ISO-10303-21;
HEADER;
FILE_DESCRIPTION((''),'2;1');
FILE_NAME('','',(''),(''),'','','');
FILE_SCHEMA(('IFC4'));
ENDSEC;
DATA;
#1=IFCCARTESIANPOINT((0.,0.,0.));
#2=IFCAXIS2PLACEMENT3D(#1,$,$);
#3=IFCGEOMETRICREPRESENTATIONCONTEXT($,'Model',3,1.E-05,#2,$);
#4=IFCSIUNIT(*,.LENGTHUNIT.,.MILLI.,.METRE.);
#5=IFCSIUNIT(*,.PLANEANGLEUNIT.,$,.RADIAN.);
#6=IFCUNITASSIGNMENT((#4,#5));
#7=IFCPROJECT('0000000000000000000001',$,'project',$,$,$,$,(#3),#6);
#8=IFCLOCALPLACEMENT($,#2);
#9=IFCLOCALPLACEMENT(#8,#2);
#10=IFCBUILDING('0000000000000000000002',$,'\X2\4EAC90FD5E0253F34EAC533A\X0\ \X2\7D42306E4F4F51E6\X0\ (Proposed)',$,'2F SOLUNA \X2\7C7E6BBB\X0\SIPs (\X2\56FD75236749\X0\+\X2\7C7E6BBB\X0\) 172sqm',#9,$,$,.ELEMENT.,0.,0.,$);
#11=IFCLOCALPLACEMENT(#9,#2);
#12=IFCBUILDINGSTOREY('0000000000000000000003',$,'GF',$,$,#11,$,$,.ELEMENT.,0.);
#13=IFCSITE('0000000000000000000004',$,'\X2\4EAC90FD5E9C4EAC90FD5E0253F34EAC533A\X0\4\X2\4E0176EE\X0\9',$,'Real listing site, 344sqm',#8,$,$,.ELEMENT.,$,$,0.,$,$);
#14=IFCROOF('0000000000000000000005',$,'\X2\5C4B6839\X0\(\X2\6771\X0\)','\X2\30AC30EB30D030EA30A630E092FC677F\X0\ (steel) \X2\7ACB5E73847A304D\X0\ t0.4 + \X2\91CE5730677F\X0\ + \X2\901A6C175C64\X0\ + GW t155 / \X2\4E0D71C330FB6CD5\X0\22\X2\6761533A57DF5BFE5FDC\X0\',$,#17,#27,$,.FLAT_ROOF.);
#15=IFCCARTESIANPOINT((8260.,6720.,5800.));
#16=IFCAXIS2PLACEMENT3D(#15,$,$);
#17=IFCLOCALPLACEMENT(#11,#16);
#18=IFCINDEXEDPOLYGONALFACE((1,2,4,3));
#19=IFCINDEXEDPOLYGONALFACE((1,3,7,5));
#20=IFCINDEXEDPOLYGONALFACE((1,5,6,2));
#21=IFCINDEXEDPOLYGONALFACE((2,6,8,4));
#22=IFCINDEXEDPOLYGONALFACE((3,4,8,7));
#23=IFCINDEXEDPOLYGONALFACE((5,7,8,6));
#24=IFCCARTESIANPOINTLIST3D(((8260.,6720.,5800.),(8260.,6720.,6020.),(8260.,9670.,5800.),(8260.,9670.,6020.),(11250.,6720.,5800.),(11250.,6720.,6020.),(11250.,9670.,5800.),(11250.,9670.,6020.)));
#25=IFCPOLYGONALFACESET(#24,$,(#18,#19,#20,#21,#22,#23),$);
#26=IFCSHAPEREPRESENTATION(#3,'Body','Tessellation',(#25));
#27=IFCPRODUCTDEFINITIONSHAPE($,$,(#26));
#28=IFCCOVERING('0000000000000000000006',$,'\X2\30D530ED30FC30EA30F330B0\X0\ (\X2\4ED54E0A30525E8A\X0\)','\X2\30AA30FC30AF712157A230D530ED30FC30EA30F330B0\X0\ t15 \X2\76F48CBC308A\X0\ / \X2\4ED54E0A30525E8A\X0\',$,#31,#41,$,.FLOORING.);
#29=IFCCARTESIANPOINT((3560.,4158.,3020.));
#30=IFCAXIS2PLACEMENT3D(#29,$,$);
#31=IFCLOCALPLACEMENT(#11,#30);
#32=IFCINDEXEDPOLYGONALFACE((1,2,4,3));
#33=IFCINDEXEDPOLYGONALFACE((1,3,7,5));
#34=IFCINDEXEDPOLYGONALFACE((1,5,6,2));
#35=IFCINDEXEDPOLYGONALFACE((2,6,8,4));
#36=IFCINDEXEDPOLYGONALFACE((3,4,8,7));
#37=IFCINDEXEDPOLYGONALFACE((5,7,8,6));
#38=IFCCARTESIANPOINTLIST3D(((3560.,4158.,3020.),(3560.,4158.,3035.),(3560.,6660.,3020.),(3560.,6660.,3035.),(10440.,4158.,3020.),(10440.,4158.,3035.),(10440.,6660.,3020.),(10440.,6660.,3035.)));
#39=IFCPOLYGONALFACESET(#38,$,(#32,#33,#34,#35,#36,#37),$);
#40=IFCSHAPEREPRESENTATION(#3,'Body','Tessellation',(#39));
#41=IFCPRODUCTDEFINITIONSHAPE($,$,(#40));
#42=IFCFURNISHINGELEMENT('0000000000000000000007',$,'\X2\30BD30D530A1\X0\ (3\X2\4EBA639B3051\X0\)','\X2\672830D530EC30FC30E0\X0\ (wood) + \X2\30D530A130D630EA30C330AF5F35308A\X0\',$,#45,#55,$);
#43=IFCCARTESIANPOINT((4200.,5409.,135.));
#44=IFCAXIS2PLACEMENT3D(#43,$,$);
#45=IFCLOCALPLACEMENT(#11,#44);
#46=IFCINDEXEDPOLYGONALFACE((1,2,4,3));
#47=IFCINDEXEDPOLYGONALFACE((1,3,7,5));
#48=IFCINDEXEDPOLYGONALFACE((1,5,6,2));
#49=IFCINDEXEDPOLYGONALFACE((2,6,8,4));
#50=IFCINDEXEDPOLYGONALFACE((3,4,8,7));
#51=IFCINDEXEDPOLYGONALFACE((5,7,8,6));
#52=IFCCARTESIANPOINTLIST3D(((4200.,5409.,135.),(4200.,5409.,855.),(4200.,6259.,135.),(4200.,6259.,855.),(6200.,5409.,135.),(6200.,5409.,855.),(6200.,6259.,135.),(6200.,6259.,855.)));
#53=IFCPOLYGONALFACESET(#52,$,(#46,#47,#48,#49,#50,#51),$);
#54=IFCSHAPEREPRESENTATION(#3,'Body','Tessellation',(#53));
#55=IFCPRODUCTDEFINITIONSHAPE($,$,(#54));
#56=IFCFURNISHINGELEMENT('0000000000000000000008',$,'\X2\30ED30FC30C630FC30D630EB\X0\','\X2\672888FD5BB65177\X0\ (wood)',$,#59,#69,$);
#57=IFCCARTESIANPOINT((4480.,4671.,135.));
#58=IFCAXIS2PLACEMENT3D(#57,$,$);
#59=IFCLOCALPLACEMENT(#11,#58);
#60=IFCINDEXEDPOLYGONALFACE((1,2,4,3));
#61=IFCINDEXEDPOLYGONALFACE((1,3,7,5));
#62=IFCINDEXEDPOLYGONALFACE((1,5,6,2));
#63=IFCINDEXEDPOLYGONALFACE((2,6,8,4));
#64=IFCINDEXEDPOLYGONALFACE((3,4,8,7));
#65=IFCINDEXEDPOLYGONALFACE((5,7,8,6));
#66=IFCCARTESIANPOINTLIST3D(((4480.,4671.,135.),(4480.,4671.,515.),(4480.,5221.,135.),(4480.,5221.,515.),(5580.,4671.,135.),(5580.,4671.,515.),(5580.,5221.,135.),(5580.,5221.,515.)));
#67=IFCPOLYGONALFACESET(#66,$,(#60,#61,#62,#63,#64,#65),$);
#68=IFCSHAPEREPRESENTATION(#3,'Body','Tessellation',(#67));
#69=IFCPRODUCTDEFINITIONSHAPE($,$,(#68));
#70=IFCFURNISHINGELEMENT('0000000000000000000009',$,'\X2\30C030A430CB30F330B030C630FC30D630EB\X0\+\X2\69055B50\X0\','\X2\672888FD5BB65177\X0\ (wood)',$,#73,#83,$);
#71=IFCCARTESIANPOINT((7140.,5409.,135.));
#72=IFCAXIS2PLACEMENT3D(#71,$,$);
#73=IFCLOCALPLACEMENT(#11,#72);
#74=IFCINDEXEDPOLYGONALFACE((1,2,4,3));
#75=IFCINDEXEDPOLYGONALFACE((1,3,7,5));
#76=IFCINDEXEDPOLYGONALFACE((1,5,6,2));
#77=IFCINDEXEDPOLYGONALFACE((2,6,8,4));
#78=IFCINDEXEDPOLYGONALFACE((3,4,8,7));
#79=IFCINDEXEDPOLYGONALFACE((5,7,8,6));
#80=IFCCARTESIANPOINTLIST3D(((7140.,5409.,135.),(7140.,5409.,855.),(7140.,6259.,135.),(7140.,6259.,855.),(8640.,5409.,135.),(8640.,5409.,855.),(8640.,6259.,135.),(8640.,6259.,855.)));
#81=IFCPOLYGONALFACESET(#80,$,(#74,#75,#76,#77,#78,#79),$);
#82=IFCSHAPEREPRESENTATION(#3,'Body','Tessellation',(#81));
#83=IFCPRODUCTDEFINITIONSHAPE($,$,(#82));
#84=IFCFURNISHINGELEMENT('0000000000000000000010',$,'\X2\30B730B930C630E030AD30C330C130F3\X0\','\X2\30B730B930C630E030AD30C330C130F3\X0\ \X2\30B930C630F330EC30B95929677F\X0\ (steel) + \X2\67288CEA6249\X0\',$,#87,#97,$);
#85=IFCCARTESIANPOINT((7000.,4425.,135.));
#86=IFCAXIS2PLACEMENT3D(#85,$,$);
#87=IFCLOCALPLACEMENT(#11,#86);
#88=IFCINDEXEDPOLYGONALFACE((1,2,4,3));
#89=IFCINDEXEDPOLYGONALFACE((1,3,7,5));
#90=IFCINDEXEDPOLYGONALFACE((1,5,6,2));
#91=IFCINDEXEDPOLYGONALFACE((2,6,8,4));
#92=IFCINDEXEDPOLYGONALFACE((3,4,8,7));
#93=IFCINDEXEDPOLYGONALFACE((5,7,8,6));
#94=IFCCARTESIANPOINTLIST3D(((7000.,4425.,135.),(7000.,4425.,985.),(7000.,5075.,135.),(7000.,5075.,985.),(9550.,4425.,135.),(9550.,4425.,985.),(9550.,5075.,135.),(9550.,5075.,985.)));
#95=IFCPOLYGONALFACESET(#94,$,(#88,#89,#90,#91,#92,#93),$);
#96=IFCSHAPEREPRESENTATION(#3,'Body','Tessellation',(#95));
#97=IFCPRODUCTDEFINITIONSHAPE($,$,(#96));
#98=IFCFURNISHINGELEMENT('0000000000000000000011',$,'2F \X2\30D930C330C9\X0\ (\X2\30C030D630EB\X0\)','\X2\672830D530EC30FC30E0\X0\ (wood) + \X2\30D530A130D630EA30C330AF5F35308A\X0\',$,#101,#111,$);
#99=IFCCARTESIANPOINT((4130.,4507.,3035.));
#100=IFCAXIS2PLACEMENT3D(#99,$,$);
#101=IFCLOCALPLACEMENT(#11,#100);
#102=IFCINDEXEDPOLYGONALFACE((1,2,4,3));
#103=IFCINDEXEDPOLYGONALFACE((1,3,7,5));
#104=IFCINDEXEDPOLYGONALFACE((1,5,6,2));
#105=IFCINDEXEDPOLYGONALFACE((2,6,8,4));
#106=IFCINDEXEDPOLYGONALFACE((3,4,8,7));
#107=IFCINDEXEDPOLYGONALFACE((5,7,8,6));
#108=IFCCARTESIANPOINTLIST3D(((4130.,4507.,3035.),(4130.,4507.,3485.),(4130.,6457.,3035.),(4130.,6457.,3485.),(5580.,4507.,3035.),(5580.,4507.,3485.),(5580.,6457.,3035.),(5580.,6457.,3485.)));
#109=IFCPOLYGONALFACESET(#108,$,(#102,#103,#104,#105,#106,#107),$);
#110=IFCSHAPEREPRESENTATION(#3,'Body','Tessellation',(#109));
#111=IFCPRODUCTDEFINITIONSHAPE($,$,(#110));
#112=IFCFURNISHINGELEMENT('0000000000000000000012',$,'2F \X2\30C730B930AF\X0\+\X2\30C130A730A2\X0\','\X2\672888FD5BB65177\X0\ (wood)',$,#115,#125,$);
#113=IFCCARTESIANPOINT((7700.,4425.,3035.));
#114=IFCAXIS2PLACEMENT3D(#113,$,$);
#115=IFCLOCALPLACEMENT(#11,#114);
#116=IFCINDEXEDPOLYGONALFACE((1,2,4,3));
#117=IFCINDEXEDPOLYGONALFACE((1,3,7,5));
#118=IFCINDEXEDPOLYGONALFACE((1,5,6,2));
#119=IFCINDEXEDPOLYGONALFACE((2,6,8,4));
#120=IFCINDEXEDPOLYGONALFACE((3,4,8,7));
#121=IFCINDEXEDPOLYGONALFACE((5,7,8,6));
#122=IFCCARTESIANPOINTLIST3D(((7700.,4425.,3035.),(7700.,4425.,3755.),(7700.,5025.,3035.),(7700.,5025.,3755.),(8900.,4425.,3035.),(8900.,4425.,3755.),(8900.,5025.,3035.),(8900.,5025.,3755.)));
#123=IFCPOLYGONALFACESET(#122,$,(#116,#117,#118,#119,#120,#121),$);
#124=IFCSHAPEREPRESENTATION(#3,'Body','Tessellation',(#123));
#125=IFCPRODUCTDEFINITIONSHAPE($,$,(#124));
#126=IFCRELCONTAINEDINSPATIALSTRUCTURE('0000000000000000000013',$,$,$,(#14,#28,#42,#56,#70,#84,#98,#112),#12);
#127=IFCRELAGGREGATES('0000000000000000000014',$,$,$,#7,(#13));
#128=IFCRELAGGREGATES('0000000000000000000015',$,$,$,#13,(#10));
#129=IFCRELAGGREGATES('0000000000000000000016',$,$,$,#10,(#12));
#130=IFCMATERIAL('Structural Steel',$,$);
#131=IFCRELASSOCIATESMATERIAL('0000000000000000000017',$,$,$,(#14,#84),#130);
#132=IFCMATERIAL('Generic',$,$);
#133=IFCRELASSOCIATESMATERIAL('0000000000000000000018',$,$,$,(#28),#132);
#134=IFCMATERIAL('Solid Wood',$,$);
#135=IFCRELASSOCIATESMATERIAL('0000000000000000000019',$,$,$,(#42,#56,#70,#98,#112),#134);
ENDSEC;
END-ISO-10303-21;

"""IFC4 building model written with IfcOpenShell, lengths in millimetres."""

from ifc_helpers import new_model, si_unit, frame, frame_2d, origin, place, context, project, spatial, rectangle, extrude, material, element, save


model = new_model("IFC4")

# Units and contexts
model_context = context("Model", 3, precision=1e-05, world=origin())
ifc_project = project(units=[si_unit("LENGTHUNIT", "METRE", prefix="MILLI"), si_unit("PLANEANGLEUNIT", "RADIAN")], contexts=[model_context])

# Site, building, storey
site_placement = place(None, origin())
site = spatial("IfcSite", under=ifc_project, at=site_placement, Name="京都府京都市右京区4丁目9", ObjectType="Real listing site, 344sqm", CompositionType="ELEMENT", RefElevation=0.0)
building_placement = place(site_placement, origin())
building = spatial("IfcBuilding", under=site, at=building_placement, Name="京都市右京区 終の住処 (Proposed)", ObjectType="2F SOLUNA 籾殻SIPs (国産杉+籾殻) 172sqm", CompositionType="ELEMENT", ElevationOfRefHeight=0.0, ElevationOfTerrain=0.0)
storey_placement = place(building_placement, origin())
storey = spatial("IfcBuildingStorey", under=building, at=storey_placement, Name="GF", CompositionType="ELEMENT", Elevation=0.0)

# Shared definitions
ifc_material_1 = material(Name="Solid Wood")

# Shared definitions
ifc_material_2 = material(Name="Generic")

# Roof
ifc_material_3 = material(Name="Structural Steel")
roof_placement = place(storey_placement, frame((8260.0, 6720.0, 5800.0)))
element("IfcRoof", 1, at=roof_placement, inside=storey, material=ifc_material_3, Name="屋根(東)", Description="ガルバリウム鋼板 (steel) 立平葺き t0.4 + 野地板 + 通気層 + GW t155 / 不燃・法22条区域対応", PredefinedType="FLAT_ROOF", context=model_context, shape_type="SweptSolid", body=[
    extrude(rectangle(XDim=2990.0, YDim=2950.0, at=frame_2d((1495.0, 1475.0))), frame((8260.0, 6720.0, 5800.0)), (0.0, 0.0, 1.0), 220.0),
])

# Covering
covering_placement = place(storey_placement, frame((3560.0, 4158.0, 3020.0)))
element("IfcCovering", 2, at=covering_placement, inside=storey, material=ifc_material_2, Name="フローリング (仕上げ床)", Description="オーク無垢フローリング t15 直貼り / 仕上げ床", PredefinedType="FLOORING", context=model_context, shape_type="SweptSolid", body=[
    extrude(rectangle(XDim=6880.0, YDim=2502.0, at=frame_2d((3440.0, 1251.0))), frame((3560.0, 4158.0, 3020.0)), (0.0, 0.0, 1.0), 15.0),
])

# Furnishing elements
furnishing_1_placement = place(storey_placement, frame((4200.0, 5409.0, 135.0)))
element("IfcFurnishingElement", 3, at=furnishing_1_placement, inside=storey, material=ifc_material_1, Name="ソファ (3人掛け)", Description="木フレーム (wood) + ファブリック張り", context=model_context, shape_type="SweptSolid", body=[
    extrude(rectangle(XDim=2000.0, YDim=850.0, at=frame_2d((1000.0, 425.0))), frame((4200.0, 5409.0, 135.0)), (0.0, 0.0, 1.0), 720.0),
])
furnishing_2_placement = place(storey_placement, frame((4480.0, 4671.0, 135.0)))
element("IfcFurnishingElement", 4, at=furnishing_2_placement, inside=storey, material=ifc_material_1, Name="ローテーブル", Description="木製家具 (wood)", context=model_context, shape_type="SweptSolid", body=[
    extrude(rectangle(XDim=1100.0, YDim=550.0, at=frame_2d((550.0, 275.0))), frame((4480.0, 4671.0, 135.0)), (0.0, 0.0, 1.0), 380.0),
])
furnishing_3_placement = place(storey_placement, frame((7140.0, 5409.0, 135.0)))
element("IfcFurnishingElement", 5, at=furnishing_3_placement, inside=storey, material=ifc_material_1, Name="ダイニングテーブル+椅子", Description="木製家具 (wood)", context=model_context, shape_type="SweptSolid", body=[
    extrude(rectangle(XDim=1500.0, YDim=850.0, at=frame_2d((750.0, 425.0))), frame((7140.0, 5409.0, 135.0)), (0.0, 0.0, 1.0), 720.0),
])
furnishing_4_placement = place(storey_placement, frame((7000.0, 4425.0, 135.0)))
element("IfcFurnishingElement", 6, at=furnishing_4_placement, inside=storey, material=ifc_material_3, Name="システムキッチン", Description="システムキッチン ステンレス天板 (steel) + 木質扉", context=model_context, shape_type="SweptSolid", body=[
    extrude(rectangle(XDim=2550.0, YDim=650.0, at=frame_2d((1275.0, 325.0))), frame((7000.0, 4425.0, 135.0)), (0.0, 0.0, 1.0), 850.0),
])
furnishing_5_placement = place(storey_placement, frame((4130.0, 4507.0, 3035.0)))
element("IfcFurnishingElement", 7, at=furnishing_5_placement, inside=storey, material=ifc_material_1, Name="2F ベッド (ダブル)", Description="木フレーム (wood) + ファブリック張り", context=model_context, shape_type="SweptSolid", body=[
    extrude(rectangle(XDim=1450.0, YDim=1950.0, at=frame_2d((725.0, 975.0))), frame((4130.0, 4507.0, 3035.0)), (0.0, 0.0, 1.0), 450.0),
])
furnishing_6_placement = place(storey_placement, frame((7700.0, 4425.0, 3035.0)))
element("IfcFurnishingElement", 8, at=furnishing_6_placement, inside=storey, material=ifc_material_1, Name="2F デスク+チェア", Description="木製家具 (wood)", context=model_context, shape_type="SweptSolid", body=[
    extrude(rectangle(XDim=1200.0, YDim=600.0, at=frame_2d((600.0, 300.0))), frame((7700.0, 4425.0, 3035.0)), (0.0, 0.0, 1.0), 720.0),
])

save(model, "model.ifc")
